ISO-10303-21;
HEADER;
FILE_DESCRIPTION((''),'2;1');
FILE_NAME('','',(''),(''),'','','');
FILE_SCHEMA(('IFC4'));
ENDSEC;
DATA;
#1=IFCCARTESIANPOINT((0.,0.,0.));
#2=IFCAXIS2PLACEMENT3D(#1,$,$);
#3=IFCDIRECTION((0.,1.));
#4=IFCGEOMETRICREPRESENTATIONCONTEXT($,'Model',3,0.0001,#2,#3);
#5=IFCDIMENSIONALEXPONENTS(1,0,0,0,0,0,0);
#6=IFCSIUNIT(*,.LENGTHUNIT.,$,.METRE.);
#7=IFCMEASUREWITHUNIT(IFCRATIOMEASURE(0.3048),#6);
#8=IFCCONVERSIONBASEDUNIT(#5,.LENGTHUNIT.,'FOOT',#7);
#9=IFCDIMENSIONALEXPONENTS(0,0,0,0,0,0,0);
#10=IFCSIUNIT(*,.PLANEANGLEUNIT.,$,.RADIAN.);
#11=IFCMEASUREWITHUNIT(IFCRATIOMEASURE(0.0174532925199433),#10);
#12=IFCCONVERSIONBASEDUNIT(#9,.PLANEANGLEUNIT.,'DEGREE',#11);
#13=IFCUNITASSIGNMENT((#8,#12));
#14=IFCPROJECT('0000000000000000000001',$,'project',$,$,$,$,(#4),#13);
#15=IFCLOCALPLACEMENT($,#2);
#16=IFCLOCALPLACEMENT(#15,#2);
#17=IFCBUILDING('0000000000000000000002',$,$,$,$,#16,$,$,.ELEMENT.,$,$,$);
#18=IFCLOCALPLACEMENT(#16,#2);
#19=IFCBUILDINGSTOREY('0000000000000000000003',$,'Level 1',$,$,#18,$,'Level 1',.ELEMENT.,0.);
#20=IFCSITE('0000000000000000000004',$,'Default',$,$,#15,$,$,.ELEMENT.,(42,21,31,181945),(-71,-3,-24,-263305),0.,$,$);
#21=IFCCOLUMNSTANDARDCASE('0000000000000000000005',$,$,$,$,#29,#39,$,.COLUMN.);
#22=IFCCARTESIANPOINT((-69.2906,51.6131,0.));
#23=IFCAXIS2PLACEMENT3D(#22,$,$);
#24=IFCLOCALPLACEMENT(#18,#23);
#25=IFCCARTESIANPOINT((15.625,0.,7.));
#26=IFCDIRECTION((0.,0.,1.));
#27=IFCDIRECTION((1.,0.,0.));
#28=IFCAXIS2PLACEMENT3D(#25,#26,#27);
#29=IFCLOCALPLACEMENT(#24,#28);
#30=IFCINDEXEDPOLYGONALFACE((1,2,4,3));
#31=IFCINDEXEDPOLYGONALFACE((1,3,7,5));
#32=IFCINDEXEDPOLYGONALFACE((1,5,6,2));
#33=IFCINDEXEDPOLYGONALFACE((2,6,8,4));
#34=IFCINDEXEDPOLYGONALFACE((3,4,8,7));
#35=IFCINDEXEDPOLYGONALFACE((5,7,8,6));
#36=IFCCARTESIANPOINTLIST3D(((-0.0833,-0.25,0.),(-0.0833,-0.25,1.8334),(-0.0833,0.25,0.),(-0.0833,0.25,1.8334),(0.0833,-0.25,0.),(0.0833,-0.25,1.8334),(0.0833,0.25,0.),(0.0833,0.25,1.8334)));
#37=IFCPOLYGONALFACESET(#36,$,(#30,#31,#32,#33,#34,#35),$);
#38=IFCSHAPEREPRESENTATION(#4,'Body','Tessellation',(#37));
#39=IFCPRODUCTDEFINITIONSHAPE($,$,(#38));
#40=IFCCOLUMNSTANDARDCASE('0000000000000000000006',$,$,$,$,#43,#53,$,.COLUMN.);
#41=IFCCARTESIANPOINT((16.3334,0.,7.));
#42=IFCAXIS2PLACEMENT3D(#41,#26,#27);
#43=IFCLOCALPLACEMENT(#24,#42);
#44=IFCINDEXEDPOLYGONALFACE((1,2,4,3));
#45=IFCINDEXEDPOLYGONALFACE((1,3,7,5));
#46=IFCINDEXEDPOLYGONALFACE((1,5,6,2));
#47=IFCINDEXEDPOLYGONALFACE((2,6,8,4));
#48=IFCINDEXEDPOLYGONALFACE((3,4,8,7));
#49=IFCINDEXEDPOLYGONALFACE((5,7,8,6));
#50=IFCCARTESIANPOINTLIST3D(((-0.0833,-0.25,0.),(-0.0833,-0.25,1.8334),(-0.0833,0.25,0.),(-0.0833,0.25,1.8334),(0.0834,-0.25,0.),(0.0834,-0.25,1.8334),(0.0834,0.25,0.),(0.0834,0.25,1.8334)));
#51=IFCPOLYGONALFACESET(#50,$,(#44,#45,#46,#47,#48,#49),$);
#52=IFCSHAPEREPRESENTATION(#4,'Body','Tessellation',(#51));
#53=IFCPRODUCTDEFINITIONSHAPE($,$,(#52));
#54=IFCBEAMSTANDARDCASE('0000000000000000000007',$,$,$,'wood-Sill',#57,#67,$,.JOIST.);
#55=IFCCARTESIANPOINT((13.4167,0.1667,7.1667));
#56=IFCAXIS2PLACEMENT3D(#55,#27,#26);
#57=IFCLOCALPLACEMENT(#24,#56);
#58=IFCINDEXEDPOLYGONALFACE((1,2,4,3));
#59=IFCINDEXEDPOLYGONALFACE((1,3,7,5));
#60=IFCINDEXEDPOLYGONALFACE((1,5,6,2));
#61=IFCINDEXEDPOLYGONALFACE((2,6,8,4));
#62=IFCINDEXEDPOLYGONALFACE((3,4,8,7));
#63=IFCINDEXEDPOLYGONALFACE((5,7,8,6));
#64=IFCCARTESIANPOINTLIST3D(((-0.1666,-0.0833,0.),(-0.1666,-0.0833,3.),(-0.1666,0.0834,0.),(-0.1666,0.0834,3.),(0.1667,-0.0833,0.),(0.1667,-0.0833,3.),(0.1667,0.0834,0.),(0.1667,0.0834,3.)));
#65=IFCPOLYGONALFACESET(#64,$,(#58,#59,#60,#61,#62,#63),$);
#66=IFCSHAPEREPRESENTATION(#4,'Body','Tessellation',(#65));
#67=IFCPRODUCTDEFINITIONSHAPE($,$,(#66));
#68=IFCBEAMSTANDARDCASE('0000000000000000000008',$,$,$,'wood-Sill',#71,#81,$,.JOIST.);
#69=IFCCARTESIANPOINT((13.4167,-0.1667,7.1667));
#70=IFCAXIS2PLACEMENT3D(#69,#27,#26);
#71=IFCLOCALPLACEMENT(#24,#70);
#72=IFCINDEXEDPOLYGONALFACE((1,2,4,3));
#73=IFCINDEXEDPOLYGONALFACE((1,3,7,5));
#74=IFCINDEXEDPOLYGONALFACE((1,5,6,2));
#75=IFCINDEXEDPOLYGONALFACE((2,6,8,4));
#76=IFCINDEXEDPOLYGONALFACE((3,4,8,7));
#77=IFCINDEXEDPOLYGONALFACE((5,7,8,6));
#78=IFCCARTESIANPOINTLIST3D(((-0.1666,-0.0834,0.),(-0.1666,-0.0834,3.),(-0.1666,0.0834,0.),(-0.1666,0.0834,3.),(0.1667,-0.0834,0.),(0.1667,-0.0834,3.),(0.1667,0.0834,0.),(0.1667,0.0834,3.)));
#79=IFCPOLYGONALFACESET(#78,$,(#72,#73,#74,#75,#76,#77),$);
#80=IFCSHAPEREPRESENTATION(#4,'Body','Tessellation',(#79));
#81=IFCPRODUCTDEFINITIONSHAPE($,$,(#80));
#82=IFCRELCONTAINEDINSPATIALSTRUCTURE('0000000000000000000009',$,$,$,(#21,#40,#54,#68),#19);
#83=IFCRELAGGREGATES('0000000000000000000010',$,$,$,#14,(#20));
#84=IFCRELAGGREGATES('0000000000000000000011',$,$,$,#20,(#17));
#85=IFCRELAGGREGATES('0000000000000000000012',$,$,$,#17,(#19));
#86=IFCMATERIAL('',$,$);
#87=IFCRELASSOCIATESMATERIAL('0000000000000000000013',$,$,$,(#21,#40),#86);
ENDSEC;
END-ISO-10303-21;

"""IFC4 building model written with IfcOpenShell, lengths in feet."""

from ifc_helpers import new_model, entity, si_unit, converted_unit, direction, frame, origin, origin_with_axes, place, context, project, spatial, rectangle, extrude, material, element, save


model = new_model("IFC4")

# Units and contexts
model_context = context("Model", 3, precision=0.0001, world=origin(), true_north=direction((0.0, 1.0)))
ifc_project = project(units=[converted_unit("LENGTHUNIT", "FOOT", entity("IfcRatioMeasure", 0.3048), si_unit("LENGTHUNIT", "METRE"), dimensions=[1, 0, 0, 0, 0, 0, 0]), converted_unit("PLANEANGLEUNIT", "DEGREE", entity("IfcRatioMeasure", 0.0174532925199433), si_unit("PLANEANGLEUNIT", "RADIAN"), dimensions=[0, 0, 0, 0, 0, 0, 0])], contexts=[model_context])

# Site, building, storey
site_placement = place(None, origin())
site = spatial("IfcSite", under=ifc_project, at=site_placement, Name="Default", CompositionType="ELEMENT", RefLatitude=(42, 21, 31, 181945), RefLongitude=(-71, -3, -24, -263305), RefElevation=0.0)
building_placement = place(site_placement, origin())
building = spatial("IfcBuilding", under=site, at=building_placement, CompositionType="ELEMENT")
storey_placement = place(building_placement, origin())
storey = spatial("IfcBuildingStorey", under=building, at=storey_placement, Name="Level 1", LongName="Level 1", CompositionType="ELEMENT", Elevation=0.0)

# Columns
placement_1 = place(storey_placement, frame((-69.2906, 51.6131, 0.0)))
ifc_material_1 = material(Name="")
for number, where, z_axis, x_axis in (
    (1, (15.625, 0.0, 7.0), (0.0, 0.0, 1.0), (1.0, 0.0, 0.0)),
    (2, (16.3334, 0.0, 7.0), (0.0, 0.0, 1.0), (1.0, 0.0, 0.0)),
):
    element("IfcColumnStandardCase", number, at=place(placement_1, frame(where, z_axis=z_axis, x_axis=x_axis)), inside=storey, material=ifc_material_1, PredefinedType="COLUMN", context=model_context, shape_type="SweptSolid", body=[
        extrude(rectangle(XDim=0.1667, YDim=0.5), origin(), (0.0, 0.0, 1.0), 1.8334),
    ])

# Beams
for number, where, z_axis, x_axis in (
    (3, (13.4167, 0.1667, 7.1667), (1.0, 0.0, 0.0), (0.0, 0.0, 1.0)),
    (4, (13.4167, -0.1667, 7.1667), (1.0, 0.0, 0.0), (0.0, 0.0, 1.0)),
):
    element("IfcBeamStandardCase", number, at=place(placement_1, frame(where, z_axis=z_axis, x_axis=x_axis)), inside=storey, ObjectType="wood-Sill", PredefinedType="JOIST", context=model_context, shape_type="SweptSolid", body=[
        extrude(rectangle(XDim=0.3333, YDim=0.1667), origin_with_axes(), (0.0, 0.0, 1.0), 3.0),
    ])

save(model, "model.ifc")
